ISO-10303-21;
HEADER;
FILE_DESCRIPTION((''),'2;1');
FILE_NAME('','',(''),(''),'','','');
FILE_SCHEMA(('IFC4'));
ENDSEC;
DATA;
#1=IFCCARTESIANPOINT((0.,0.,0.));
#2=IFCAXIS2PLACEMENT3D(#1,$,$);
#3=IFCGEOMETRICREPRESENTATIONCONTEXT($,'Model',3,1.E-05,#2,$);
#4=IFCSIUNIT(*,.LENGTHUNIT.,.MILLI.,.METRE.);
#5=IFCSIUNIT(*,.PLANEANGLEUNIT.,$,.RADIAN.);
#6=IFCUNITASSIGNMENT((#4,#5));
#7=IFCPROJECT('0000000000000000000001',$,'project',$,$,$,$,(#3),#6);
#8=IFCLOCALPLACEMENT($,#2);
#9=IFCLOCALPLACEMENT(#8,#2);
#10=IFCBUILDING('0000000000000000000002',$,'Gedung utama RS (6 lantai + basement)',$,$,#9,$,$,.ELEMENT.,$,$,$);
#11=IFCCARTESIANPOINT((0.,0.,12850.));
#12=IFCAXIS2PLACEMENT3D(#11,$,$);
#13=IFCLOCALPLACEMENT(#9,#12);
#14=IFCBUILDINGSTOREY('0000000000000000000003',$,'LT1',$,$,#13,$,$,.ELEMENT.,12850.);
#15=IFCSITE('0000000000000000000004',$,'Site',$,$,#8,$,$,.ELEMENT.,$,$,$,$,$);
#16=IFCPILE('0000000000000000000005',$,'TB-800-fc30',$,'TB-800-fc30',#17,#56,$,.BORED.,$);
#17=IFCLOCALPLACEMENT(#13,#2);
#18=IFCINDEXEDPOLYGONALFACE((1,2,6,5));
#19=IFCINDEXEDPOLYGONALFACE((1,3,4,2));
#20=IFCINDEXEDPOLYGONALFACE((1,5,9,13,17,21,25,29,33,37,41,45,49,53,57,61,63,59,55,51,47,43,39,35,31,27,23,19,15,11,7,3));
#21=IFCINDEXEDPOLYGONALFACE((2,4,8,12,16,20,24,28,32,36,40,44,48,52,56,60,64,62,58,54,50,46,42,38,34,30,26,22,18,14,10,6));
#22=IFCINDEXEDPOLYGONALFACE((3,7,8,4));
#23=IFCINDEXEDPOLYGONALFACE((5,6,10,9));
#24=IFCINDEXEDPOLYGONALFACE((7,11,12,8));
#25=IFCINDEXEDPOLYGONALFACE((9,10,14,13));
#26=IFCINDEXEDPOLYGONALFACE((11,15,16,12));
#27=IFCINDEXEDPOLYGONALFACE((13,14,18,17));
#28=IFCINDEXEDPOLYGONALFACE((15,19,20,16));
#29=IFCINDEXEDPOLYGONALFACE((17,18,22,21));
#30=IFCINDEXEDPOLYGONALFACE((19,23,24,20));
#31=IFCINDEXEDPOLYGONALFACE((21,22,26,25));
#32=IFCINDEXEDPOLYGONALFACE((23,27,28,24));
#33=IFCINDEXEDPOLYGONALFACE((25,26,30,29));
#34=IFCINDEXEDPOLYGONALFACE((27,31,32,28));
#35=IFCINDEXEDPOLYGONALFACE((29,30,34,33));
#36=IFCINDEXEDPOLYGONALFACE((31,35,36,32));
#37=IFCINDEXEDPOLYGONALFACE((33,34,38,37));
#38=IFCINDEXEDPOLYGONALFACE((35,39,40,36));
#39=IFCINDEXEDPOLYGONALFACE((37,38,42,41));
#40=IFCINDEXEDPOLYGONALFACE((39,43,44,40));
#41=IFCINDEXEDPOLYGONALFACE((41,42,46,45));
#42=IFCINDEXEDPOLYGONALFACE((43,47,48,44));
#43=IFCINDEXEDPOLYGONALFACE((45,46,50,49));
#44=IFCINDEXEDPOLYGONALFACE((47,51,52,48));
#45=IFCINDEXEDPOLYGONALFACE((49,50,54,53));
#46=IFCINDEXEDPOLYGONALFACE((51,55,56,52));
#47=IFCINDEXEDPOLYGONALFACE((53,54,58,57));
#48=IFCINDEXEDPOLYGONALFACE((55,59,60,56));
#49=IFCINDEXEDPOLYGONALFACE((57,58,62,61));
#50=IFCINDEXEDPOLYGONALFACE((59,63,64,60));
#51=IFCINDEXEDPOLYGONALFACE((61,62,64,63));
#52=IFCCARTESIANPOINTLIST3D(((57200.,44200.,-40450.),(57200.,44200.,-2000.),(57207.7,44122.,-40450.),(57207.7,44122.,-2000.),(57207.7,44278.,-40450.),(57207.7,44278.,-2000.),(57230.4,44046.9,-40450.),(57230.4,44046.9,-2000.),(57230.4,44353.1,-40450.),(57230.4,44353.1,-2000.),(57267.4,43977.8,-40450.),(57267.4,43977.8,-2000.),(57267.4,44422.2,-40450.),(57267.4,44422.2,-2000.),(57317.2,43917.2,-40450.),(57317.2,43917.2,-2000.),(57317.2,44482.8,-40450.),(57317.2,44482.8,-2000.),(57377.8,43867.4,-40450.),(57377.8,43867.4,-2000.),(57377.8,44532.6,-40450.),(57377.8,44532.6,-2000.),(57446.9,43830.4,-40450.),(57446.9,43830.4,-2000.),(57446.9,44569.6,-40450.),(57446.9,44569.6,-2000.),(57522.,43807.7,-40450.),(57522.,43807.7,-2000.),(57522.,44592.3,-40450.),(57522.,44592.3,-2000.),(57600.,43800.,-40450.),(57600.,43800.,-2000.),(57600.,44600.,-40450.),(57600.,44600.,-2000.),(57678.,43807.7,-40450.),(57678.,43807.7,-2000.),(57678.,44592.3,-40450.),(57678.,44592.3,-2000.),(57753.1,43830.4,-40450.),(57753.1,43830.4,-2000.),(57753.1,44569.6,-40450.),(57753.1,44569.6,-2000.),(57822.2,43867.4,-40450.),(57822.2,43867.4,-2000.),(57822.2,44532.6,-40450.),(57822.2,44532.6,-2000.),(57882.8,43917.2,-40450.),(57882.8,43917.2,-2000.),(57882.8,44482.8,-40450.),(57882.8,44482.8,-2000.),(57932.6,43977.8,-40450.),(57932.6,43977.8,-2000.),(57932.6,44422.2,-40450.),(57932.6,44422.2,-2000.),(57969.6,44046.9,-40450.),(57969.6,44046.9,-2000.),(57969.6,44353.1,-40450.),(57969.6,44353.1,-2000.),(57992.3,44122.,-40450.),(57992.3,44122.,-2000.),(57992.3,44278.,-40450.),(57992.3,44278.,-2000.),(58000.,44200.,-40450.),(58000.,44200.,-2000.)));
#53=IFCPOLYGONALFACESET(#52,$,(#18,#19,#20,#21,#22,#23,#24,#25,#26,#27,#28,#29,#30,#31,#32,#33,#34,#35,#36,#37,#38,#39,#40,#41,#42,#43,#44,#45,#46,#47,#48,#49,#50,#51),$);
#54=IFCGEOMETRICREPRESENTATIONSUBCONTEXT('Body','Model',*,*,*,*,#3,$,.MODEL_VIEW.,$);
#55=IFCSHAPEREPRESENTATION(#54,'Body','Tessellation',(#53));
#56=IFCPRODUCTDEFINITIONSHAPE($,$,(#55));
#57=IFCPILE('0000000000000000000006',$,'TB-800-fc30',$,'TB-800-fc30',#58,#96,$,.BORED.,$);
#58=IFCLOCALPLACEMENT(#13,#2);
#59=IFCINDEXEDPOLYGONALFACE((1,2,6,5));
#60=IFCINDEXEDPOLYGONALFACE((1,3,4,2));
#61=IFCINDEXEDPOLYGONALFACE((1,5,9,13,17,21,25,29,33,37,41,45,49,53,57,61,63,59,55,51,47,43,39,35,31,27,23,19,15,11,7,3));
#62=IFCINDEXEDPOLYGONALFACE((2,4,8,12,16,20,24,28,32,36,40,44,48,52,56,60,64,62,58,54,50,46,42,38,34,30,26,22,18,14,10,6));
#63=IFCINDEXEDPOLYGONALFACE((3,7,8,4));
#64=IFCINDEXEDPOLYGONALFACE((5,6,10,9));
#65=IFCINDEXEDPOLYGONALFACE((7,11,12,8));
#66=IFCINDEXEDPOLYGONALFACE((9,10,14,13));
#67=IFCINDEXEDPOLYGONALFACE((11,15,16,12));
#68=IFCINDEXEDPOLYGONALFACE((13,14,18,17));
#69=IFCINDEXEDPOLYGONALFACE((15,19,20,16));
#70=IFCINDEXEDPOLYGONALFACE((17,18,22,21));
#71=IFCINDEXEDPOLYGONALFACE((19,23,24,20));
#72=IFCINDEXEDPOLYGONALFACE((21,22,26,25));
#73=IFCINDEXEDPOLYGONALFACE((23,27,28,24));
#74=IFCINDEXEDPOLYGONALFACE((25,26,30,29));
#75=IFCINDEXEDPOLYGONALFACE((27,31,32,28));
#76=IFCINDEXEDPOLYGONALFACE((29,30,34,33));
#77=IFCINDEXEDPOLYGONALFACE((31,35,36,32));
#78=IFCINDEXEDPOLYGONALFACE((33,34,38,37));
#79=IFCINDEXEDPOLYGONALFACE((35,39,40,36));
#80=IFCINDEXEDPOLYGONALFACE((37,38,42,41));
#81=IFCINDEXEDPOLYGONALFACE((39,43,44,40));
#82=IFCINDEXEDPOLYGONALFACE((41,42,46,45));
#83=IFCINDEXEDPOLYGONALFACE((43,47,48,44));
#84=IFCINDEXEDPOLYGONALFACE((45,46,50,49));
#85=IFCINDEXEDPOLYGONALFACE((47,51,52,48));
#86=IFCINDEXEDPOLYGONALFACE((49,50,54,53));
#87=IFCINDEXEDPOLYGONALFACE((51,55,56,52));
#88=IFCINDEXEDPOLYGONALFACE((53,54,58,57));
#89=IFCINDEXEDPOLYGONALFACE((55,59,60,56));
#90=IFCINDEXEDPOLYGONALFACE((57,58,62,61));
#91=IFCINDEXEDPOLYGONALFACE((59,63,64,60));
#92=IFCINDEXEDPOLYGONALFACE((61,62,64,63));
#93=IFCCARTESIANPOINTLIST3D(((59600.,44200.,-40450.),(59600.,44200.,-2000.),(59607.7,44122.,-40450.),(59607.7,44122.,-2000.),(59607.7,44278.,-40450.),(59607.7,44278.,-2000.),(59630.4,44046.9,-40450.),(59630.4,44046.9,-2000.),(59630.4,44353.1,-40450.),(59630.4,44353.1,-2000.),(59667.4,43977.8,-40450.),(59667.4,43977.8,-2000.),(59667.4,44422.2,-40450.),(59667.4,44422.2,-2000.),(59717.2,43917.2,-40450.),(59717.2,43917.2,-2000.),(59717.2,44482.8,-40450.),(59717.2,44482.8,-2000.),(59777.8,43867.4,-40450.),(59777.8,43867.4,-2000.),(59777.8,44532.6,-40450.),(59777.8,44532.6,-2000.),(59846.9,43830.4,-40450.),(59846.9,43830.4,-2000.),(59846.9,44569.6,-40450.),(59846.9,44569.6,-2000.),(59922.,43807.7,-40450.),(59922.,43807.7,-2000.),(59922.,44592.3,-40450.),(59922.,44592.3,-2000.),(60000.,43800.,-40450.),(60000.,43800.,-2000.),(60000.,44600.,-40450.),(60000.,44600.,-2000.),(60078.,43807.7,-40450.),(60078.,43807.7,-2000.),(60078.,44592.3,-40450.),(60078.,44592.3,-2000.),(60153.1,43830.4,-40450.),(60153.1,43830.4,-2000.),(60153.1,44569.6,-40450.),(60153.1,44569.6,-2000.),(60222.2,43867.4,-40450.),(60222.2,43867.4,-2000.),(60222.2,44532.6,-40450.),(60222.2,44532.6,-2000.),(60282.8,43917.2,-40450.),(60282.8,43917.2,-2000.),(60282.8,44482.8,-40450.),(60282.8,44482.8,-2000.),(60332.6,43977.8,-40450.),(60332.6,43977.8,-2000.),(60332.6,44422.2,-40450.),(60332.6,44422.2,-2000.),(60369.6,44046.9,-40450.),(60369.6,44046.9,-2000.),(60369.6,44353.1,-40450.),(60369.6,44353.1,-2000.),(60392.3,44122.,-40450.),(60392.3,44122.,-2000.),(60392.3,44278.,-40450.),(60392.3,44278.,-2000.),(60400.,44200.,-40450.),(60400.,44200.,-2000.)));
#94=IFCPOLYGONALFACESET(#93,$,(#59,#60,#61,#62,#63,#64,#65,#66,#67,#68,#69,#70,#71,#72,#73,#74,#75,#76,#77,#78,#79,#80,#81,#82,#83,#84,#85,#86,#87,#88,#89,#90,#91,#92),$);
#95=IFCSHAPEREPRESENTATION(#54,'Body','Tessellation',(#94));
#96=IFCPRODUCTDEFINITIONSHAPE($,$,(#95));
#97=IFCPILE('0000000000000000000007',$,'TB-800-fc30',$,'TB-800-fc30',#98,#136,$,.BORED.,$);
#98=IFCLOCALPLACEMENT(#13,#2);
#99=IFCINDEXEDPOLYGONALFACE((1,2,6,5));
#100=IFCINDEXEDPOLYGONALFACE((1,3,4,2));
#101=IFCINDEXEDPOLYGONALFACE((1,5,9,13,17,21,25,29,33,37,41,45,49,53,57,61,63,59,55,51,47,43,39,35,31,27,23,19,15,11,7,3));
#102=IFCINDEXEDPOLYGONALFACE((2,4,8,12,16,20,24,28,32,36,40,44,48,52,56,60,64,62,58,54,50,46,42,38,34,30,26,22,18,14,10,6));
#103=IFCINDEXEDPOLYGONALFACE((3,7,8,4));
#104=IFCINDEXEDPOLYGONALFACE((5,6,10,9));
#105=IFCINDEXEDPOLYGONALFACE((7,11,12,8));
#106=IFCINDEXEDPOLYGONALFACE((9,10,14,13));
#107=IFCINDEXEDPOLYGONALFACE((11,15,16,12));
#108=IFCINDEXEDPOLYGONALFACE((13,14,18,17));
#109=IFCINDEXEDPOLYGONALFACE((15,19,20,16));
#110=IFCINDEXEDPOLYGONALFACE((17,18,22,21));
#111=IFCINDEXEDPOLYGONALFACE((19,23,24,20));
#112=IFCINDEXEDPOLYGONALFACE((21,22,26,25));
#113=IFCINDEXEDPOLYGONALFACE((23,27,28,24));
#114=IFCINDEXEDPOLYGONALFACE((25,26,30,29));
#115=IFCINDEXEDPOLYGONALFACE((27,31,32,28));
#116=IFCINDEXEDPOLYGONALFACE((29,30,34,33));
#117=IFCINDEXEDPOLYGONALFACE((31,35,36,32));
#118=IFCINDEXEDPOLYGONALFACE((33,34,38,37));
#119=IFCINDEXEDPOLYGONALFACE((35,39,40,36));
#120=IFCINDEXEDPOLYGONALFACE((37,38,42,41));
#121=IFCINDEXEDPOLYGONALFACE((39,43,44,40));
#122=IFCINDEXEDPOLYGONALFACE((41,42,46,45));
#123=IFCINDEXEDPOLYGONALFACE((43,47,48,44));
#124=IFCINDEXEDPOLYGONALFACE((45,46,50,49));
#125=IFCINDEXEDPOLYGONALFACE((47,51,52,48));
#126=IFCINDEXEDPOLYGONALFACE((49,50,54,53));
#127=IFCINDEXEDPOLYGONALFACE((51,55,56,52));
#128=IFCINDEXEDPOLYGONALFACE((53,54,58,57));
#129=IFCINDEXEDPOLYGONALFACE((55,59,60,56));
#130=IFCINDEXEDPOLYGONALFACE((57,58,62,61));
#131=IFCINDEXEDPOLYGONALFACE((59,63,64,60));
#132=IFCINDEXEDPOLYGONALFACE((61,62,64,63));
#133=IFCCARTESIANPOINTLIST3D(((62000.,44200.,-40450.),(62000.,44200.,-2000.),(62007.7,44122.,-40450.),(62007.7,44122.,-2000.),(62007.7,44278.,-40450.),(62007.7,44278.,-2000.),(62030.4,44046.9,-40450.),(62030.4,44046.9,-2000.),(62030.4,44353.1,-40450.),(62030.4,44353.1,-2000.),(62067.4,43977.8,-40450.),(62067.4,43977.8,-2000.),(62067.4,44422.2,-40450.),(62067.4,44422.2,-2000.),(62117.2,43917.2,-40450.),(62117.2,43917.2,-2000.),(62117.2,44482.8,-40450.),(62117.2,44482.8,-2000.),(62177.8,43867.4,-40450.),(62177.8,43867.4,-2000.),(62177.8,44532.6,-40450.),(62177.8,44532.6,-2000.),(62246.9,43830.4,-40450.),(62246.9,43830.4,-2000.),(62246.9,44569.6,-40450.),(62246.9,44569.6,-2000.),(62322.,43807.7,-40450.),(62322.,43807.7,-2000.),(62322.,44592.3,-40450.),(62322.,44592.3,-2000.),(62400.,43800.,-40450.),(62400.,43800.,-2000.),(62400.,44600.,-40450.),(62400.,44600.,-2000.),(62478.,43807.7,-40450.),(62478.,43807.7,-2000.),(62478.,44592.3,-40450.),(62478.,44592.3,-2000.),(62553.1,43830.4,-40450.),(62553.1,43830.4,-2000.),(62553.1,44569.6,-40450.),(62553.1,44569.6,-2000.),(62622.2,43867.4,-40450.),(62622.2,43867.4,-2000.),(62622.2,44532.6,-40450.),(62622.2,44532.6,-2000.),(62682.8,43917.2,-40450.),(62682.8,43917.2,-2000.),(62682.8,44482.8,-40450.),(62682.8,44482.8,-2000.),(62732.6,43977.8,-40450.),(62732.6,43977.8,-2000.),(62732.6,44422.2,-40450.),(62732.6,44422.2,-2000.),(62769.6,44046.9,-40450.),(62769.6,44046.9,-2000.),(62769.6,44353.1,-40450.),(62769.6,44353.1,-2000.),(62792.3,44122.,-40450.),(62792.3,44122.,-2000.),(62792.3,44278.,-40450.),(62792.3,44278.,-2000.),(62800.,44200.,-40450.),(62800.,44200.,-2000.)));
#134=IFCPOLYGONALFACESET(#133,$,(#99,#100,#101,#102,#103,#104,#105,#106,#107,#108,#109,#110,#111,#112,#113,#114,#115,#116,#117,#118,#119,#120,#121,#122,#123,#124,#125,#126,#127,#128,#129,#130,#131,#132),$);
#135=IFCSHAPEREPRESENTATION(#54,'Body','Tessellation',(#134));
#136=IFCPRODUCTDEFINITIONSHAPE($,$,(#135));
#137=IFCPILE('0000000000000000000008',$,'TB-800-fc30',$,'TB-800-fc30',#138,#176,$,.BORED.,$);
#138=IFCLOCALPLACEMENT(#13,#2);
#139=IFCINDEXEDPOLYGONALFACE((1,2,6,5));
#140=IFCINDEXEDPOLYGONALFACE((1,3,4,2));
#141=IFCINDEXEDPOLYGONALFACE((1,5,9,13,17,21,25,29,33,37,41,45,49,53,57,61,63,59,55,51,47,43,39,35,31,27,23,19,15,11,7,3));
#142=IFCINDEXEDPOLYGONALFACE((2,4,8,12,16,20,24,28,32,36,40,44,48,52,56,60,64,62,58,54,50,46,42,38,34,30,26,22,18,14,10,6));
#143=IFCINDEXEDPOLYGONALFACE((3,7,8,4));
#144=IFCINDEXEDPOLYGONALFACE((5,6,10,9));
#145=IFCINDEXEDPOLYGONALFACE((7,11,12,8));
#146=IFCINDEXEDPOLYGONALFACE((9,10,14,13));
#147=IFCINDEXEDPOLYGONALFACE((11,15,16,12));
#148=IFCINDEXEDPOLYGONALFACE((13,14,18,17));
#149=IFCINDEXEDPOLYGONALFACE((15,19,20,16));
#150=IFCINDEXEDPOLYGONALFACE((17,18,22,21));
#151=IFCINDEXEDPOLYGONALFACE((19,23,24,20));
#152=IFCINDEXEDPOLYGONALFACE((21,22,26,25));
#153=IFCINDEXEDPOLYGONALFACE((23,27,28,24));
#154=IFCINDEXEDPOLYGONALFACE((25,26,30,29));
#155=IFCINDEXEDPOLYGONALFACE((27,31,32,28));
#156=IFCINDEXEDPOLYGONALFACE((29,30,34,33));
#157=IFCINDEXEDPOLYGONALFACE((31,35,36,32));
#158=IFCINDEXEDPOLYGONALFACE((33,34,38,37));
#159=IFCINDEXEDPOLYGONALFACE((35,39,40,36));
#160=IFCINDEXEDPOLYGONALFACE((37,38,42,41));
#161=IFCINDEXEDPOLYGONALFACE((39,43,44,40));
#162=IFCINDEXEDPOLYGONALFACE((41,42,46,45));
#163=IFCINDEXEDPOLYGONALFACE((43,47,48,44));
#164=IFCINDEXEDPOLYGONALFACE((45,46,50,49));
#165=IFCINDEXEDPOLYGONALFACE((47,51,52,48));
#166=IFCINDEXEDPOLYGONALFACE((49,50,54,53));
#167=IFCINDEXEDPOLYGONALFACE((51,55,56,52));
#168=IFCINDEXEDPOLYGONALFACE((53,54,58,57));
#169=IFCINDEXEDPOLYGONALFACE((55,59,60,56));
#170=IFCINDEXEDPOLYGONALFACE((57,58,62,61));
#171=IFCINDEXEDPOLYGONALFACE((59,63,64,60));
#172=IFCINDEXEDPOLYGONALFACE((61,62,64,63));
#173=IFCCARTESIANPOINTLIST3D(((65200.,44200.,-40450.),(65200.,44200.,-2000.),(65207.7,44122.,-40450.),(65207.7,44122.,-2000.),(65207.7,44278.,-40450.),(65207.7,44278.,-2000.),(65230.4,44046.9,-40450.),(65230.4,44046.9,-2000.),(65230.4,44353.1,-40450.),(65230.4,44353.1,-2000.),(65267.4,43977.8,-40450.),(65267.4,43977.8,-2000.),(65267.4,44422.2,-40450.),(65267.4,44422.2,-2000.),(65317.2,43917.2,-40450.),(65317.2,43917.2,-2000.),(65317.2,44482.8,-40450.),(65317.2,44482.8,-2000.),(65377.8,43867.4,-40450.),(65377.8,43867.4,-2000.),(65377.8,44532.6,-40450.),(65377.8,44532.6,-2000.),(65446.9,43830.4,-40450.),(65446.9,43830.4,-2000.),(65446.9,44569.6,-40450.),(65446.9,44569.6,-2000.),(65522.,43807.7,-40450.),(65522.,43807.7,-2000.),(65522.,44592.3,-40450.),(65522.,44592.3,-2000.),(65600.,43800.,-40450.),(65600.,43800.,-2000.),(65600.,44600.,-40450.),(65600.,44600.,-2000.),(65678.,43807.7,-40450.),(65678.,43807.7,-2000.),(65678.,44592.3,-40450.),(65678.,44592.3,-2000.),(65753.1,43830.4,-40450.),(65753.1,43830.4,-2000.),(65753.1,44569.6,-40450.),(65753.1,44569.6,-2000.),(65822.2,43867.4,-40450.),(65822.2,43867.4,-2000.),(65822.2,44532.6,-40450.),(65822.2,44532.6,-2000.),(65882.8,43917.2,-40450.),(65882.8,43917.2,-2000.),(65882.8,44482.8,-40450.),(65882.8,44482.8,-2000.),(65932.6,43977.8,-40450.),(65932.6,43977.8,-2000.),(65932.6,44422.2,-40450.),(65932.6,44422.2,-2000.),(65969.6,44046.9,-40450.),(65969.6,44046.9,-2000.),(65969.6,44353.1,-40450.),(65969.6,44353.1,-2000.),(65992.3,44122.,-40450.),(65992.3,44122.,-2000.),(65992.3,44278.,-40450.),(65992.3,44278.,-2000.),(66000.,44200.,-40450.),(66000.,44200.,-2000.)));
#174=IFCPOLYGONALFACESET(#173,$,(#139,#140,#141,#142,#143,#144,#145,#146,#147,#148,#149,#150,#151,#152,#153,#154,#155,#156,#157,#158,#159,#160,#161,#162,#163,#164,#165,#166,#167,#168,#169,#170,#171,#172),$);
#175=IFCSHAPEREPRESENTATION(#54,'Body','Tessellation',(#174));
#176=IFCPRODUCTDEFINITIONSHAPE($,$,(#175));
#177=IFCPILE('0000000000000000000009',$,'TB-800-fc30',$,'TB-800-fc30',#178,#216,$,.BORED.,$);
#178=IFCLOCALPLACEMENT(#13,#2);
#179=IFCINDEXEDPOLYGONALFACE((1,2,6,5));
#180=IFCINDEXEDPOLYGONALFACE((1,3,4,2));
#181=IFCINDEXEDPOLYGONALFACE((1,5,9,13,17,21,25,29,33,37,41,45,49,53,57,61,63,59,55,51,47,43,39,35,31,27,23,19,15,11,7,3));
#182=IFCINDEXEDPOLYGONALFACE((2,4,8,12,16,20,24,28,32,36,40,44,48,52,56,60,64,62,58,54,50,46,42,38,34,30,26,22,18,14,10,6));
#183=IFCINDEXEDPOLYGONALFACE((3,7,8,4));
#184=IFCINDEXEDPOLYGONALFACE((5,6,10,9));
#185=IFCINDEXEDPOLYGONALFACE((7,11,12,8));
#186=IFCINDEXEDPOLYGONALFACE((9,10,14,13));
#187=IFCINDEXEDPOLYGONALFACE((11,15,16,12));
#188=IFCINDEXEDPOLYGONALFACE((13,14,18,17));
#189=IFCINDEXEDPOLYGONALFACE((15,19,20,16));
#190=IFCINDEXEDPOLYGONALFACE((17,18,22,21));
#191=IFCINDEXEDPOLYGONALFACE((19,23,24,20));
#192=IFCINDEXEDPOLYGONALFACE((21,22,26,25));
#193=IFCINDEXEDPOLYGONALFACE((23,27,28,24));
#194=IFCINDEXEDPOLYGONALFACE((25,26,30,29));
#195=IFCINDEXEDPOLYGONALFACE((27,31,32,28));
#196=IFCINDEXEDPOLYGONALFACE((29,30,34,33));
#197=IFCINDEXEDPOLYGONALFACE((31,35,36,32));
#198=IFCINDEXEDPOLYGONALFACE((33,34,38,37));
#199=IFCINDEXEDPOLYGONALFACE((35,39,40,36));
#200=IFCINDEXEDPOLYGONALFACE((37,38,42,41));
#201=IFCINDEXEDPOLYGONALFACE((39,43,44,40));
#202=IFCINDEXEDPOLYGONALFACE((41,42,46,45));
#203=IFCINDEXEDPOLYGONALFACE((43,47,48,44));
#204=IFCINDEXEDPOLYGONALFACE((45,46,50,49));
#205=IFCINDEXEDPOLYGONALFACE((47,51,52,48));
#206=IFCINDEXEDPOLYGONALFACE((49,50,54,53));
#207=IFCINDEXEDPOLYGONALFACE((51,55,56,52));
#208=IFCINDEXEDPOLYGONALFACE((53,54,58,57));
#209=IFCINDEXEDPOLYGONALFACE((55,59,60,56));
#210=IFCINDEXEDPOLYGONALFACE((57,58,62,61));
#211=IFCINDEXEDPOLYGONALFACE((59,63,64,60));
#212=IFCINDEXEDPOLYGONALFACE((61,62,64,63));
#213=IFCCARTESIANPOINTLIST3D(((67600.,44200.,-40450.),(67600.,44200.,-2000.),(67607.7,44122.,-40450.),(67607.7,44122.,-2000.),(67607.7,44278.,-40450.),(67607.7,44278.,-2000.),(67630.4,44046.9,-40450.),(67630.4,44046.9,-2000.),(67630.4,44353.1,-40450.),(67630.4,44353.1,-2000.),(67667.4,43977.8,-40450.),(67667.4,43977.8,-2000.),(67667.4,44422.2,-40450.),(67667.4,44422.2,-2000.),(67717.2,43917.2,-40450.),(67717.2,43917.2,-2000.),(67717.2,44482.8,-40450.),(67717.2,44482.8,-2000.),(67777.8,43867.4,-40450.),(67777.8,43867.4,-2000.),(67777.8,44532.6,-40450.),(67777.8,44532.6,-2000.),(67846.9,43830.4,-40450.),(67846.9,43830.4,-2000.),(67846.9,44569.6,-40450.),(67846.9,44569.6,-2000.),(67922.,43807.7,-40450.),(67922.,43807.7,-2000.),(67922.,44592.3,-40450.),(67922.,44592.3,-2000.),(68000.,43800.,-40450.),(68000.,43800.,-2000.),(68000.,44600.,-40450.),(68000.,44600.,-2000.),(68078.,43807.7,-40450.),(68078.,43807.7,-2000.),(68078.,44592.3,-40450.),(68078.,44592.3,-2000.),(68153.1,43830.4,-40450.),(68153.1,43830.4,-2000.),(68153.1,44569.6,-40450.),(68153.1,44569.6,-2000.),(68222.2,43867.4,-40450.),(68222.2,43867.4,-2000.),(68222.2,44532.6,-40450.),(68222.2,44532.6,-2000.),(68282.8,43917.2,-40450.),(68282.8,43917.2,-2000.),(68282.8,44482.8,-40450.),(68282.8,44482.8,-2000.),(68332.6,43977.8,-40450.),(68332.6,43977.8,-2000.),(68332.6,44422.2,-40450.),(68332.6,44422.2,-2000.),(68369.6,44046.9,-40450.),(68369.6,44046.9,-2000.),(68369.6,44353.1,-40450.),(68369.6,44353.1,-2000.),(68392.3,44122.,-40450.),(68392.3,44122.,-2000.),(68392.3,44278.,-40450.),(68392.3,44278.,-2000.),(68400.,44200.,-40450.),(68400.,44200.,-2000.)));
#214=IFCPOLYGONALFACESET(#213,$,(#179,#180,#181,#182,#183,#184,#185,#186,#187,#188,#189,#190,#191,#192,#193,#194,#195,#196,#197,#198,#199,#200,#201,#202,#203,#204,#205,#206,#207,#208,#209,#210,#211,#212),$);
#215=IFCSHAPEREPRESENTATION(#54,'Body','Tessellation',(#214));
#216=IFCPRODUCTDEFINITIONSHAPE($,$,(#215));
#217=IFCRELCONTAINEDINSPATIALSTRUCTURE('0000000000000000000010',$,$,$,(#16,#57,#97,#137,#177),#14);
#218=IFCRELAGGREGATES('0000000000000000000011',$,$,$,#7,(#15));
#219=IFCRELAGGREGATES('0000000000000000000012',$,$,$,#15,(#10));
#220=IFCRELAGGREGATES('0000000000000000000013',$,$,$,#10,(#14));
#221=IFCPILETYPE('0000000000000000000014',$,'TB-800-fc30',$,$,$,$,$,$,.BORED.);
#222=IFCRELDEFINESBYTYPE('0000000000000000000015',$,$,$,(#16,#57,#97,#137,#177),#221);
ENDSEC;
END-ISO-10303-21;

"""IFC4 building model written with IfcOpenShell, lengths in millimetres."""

from ifc_helpers import new_model, si_unit, frame, origin, origin_2d, place, context, subcontext, project, spatial, circle, extrude, material_profile, profile_set, profile_usage, type_object, element, save


model = new_model("IFC4")

# Units and contexts
model_context = context("Model", 3, precision=1e-05, world=origin())
body_context = subcontext(model_context, "Body", "Model", "MODEL_VIEW")
ifc_project = project(units=[si_unit("LENGTHUNIT", "METRE", prefix="MILLI"), si_unit("PLANEANGLEUNIT", "RADIAN")], contexts=[model_context])

# Site, building, storey
site_placement = place(None, origin())
site = spatial("IfcSite", under=ifc_project, at=site_placement, Name="Site", CompositionType="ELEMENT")
building_placement = place(site_placement, origin())
building = spatial("IfcBuilding", under=site, at=building_placement, Name="Gedung utama RS (6 lantai + basement)", CompositionType="ELEMENT")
storey_placement = place(building_placement, frame((0.0, 0.0, 12850.0)))
storey = spatial("IfcBuildingStorey", under=building, at=storey_placement, Name="LT1", CompositionType="ELEMENT", Elevation=12850.0)

# Piles
ifc_material_profile_1 = material_profile(None, circle(Radius=400.0, at=origin_2d()), Name="TB-800-fc30")
ifc_profile_set_1 = profile_set([ifc_material_profile_1], Name="TB-800-fc30")
ifc_profile_usage_1 = profile_usage(ifc_profile_set_1, cardinal=5)
pile_type = type_object("IfcPileType", Name="TB-800-fc30", PredefinedType="BORED", material=ifc_profile_set_1)
for number, where, z_axis, x_axis, name in (
    (1, (57600.0, 44200.0, -40450.0), (0.0, 0.0, 1.0), (1.0, 0.0, 0.0), "TB-800-fc30"),
    (2, (60000.0, 44200.0, -40450.0), (0.0, 0.0, 1.0), (1.0, 0.0, 0.0), "TB-800-fc30"),
    (3, (62400.0, 44200.0, -40450.0), (0.0, 0.0, 1.0), (1.0, 0.0, 0.0), "TB-800-fc30"),
    (4, (65600.0, 44200.0, -40450.0), (0.0, 0.0, 1.0), (1.0, 0.0, 0.0), "TB-800-fc30"),
    (5, (68000.0, 44200.0, -40450.0), (0.0, 0.0, 1.0), (1.0, 0.0, 0.0), "TB-800-fc30"),
):
    element("IfcPile", number, at=place(storey_placement, frame(where, z_axis=z_axis, x_axis=x_axis)), inside=storey, type_object=pile_type, material=ifc_profile_usage_1, Name=name, ObjectType="TB-800-fc30", PredefinedType="BORED", context=body_context, shape_type="SweptSolid", body=[
        extrude(circle(Radius=400.0, at=origin_2d()), origin(), (0.0, 0.0, 1.0), 38450.0),
    ])

save(model, "model.ifc")
